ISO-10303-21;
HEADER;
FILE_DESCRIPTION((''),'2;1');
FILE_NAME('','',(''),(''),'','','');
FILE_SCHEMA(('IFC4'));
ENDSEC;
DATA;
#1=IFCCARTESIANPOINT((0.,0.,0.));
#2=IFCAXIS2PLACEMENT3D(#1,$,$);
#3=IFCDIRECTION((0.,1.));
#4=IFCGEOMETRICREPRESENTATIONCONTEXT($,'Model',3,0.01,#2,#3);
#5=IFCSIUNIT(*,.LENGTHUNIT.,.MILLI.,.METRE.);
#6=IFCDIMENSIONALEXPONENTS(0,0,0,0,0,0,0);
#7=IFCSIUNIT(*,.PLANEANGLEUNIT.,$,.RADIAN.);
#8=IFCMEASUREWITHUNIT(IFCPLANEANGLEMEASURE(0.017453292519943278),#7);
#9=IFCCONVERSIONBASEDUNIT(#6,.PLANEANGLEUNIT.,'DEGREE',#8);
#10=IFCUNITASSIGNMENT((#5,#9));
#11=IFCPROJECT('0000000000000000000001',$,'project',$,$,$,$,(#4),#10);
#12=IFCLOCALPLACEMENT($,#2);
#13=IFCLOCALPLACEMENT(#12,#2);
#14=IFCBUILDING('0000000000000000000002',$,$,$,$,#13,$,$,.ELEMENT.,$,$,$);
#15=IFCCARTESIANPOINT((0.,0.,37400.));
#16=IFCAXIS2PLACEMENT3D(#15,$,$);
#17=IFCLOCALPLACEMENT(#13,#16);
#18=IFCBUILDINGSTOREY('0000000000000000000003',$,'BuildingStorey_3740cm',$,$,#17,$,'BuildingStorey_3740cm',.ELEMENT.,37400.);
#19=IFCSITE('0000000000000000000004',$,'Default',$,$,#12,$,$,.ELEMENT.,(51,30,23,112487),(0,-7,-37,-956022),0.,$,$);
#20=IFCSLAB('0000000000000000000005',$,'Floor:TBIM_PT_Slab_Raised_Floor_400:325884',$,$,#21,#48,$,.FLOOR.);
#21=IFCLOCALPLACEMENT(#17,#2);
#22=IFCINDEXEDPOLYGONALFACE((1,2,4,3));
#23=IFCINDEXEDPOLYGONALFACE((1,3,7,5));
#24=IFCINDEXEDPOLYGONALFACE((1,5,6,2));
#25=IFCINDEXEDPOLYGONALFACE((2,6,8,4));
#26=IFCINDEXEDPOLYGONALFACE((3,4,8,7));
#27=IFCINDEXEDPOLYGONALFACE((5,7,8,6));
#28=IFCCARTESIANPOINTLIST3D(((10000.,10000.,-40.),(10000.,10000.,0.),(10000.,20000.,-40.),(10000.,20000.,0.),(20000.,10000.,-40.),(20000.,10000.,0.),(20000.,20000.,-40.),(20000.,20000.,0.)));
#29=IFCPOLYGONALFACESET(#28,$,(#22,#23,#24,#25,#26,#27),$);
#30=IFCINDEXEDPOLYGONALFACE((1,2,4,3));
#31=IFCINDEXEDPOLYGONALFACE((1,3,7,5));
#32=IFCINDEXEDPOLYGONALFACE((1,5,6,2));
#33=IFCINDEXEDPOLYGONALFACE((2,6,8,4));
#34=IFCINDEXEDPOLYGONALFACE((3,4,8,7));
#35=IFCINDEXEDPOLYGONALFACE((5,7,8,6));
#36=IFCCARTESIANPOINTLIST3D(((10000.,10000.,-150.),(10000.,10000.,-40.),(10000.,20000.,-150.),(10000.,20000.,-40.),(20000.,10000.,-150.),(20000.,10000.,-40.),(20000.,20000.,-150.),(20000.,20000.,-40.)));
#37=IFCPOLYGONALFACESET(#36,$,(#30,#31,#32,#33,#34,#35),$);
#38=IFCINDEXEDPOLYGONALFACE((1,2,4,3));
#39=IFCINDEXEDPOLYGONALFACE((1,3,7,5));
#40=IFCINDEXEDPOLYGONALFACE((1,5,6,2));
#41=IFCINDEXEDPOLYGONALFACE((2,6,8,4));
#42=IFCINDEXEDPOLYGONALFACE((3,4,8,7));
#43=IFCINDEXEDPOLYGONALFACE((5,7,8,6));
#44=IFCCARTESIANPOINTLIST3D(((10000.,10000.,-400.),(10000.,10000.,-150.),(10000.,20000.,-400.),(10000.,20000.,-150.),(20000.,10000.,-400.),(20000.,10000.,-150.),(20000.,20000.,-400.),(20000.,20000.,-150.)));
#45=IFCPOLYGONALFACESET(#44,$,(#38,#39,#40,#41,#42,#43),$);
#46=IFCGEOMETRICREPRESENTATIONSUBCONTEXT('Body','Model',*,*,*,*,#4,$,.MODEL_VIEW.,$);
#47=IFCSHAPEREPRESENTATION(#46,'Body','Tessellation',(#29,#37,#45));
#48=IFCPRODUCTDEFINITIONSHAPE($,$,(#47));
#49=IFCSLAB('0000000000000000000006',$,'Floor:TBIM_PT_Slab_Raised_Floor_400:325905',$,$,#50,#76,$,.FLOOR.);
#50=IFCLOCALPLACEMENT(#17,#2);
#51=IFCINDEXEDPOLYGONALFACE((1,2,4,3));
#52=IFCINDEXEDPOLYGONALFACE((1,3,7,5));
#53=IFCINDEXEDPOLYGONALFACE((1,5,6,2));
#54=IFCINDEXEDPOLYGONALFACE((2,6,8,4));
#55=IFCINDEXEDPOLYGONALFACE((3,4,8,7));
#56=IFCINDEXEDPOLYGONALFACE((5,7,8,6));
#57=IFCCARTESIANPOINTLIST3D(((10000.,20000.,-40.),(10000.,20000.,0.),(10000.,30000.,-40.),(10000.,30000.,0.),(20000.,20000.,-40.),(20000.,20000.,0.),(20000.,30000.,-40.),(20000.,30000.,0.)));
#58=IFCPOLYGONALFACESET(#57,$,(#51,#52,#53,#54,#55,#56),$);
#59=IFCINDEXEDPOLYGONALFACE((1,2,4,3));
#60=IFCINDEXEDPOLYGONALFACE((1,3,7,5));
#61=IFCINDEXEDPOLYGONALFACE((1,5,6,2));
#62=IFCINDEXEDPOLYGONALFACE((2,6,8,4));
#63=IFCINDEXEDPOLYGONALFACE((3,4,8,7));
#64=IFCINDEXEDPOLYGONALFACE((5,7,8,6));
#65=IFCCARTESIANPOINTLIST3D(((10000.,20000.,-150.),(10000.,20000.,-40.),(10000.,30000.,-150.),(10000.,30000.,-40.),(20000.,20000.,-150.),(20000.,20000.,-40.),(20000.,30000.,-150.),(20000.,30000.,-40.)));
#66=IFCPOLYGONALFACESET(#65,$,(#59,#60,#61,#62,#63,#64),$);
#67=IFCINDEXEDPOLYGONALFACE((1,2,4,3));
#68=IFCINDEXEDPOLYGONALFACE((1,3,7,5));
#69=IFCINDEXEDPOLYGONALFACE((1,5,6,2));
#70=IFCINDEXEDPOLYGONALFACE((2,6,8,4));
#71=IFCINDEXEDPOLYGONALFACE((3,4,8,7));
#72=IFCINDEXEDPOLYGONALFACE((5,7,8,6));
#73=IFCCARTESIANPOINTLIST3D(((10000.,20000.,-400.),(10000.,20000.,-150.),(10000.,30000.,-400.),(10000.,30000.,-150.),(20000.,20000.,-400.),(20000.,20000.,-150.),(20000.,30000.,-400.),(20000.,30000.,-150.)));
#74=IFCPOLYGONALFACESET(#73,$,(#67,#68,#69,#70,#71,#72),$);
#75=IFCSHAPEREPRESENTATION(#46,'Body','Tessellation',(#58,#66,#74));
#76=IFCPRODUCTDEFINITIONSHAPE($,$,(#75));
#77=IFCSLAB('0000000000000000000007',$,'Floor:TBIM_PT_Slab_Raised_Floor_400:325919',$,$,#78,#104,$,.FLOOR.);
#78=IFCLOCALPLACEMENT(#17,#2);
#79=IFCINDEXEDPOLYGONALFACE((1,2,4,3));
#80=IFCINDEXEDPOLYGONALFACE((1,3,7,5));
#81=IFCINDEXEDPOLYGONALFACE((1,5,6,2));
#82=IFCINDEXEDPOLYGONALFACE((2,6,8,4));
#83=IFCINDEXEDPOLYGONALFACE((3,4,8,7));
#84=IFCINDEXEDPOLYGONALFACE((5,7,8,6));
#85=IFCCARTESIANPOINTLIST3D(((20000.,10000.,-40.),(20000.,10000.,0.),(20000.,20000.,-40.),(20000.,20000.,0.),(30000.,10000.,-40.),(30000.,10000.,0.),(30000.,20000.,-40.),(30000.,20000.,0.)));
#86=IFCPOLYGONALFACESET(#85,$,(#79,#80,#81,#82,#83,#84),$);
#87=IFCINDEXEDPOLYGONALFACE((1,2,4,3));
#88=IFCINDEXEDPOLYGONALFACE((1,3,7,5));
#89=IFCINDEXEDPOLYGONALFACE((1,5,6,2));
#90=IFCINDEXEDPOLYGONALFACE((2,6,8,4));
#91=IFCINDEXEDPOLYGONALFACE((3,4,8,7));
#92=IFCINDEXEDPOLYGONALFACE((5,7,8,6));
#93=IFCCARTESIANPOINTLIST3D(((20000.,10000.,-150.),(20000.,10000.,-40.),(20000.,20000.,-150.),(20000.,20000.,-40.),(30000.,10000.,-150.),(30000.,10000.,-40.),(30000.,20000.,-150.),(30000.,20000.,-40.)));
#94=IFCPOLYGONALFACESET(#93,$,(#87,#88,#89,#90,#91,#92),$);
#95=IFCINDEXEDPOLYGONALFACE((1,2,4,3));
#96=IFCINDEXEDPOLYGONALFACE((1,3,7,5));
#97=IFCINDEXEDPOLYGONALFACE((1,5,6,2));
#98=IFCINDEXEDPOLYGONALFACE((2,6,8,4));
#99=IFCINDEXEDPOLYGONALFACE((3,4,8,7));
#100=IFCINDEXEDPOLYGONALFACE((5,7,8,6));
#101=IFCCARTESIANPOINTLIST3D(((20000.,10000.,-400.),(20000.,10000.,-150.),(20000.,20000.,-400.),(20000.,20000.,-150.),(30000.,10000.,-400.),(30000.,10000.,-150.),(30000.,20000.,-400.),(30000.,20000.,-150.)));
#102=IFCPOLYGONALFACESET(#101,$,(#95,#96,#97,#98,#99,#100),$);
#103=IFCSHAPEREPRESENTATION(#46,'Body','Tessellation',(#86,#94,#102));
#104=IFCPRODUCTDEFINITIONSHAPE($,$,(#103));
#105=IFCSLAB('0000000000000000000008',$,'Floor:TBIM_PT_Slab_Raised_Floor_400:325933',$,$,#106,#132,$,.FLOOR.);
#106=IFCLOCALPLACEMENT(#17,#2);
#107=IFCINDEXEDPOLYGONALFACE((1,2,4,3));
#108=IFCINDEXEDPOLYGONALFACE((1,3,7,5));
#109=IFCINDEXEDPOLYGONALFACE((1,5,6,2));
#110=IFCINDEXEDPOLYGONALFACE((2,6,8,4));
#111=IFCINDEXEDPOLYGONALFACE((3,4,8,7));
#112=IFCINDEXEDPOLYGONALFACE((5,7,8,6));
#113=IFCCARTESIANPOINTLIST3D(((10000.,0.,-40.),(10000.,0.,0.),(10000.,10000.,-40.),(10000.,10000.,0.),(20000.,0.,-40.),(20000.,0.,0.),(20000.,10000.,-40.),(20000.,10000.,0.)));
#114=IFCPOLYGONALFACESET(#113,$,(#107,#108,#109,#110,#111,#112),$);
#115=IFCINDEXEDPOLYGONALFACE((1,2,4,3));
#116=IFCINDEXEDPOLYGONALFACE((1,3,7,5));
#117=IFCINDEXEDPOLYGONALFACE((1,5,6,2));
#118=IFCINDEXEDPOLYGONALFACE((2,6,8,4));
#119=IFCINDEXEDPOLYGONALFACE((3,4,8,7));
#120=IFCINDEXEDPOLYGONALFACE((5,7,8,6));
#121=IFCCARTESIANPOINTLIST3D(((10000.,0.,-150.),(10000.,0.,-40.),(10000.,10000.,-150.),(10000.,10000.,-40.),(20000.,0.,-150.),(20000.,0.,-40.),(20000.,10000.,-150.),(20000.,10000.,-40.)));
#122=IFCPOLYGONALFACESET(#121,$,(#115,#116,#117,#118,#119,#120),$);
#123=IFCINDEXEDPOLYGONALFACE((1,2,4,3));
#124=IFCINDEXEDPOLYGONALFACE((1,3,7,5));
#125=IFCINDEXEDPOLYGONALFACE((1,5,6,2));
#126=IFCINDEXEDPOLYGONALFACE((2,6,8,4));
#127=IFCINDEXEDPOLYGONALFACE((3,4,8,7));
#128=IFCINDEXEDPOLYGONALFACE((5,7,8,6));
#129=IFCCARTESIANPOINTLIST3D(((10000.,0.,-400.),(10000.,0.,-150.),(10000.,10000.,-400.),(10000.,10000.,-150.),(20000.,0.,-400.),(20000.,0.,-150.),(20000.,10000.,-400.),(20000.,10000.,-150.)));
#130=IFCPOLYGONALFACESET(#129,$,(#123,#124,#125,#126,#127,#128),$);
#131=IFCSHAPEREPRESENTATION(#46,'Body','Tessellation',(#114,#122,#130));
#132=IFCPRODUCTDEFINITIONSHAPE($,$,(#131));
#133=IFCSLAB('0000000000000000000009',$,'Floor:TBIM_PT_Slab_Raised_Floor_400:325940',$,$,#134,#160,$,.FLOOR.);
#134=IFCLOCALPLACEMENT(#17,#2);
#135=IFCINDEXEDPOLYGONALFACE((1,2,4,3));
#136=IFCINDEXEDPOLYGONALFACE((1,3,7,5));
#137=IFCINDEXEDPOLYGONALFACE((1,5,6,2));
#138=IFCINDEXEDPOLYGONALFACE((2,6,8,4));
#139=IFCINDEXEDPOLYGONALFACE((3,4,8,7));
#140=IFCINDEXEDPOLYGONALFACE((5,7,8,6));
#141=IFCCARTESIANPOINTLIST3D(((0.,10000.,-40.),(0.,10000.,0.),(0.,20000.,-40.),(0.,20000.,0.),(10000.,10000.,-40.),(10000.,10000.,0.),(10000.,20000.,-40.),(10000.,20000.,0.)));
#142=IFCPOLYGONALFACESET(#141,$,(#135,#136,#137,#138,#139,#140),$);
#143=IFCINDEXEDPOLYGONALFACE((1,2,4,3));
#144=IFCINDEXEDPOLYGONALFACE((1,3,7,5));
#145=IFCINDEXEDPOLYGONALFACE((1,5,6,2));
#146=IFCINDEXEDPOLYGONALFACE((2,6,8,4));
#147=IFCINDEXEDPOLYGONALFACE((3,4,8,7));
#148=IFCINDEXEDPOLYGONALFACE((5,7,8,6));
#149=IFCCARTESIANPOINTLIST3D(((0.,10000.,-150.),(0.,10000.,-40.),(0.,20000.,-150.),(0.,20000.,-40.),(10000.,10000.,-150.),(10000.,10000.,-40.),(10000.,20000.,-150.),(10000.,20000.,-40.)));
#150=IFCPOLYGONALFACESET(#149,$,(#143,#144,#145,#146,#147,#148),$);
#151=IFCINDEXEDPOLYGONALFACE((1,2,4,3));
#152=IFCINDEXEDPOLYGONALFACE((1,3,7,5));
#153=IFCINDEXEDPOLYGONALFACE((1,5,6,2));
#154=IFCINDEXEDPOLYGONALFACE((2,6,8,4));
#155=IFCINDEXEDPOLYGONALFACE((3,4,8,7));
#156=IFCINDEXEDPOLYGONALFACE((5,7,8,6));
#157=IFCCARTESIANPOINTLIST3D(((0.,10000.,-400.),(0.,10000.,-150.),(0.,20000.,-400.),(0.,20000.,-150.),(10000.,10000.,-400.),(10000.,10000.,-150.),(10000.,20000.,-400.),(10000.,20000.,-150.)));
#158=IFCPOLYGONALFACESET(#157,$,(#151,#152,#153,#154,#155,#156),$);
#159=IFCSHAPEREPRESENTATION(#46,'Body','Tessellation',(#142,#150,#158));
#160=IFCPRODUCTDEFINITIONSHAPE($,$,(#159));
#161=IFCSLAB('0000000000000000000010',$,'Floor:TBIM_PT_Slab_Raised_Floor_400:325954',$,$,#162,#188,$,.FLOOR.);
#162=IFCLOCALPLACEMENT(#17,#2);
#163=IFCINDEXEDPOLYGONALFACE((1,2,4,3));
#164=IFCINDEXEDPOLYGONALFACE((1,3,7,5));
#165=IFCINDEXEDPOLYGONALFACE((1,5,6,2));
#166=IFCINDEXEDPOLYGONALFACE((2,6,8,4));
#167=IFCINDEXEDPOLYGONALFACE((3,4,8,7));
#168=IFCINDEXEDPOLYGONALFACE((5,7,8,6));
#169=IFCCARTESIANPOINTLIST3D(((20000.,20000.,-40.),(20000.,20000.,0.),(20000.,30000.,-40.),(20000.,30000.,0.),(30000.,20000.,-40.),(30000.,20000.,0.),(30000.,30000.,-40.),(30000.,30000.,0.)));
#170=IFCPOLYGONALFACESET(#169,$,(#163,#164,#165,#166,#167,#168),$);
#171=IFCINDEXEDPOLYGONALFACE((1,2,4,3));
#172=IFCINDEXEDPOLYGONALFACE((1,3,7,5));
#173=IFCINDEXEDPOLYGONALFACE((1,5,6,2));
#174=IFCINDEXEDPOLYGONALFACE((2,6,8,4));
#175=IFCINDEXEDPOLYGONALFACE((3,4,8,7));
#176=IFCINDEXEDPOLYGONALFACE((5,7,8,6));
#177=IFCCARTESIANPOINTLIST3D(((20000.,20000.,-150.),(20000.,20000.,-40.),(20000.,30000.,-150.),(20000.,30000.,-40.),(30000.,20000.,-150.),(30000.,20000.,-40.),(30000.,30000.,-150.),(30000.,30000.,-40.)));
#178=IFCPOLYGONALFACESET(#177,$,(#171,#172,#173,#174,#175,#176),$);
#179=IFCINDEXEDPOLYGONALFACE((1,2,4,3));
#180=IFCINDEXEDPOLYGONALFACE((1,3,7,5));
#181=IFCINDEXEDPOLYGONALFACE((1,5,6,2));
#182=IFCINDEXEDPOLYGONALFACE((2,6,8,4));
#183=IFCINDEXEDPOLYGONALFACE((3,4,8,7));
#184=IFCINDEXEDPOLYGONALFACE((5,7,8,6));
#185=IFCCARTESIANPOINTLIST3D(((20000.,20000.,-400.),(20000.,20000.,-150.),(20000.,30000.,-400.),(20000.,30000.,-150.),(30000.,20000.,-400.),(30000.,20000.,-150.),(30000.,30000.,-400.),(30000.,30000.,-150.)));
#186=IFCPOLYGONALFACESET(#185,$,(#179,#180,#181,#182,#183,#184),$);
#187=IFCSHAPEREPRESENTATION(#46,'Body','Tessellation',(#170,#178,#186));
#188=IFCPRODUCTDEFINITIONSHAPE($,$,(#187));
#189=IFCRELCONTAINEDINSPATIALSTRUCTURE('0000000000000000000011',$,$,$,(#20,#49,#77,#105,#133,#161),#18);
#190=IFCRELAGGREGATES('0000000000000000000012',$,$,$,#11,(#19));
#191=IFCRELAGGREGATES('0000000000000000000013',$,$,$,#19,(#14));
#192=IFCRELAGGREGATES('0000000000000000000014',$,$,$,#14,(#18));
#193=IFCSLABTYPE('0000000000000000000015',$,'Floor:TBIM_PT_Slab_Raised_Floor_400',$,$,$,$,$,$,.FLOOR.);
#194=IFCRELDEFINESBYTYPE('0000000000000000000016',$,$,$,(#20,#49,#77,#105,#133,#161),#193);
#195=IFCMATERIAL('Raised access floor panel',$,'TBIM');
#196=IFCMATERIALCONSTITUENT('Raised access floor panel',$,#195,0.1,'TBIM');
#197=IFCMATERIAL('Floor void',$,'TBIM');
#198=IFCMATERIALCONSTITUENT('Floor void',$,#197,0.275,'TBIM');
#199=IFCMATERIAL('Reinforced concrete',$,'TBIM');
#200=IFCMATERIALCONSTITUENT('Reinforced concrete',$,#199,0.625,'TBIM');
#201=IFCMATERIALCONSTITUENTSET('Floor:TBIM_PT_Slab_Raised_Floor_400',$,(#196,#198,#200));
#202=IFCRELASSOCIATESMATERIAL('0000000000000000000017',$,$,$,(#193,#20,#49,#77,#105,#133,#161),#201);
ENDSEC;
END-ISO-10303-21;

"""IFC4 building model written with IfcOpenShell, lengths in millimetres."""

from ifc_helpers import new_model, entity, si_unit, converted_unit, direction, frame, origin, place, context, subcontext, project, spatial, indexed_curve, outline, extrude, material, constituent, constituent_set, type_object, element, save


model = new_model("IFC4")

# Units and contexts
model_context = context("Model", 3, precision=0.01, world=origin(), true_north=direction((0.0, 1.0)))
body_context = subcontext(model_context, "Body", "Model", "MODEL_VIEW")
ifc_project = project(units=[si_unit("LENGTHUNIT", "METRE", prefix="MILLI"), converted_unit("PLANEANGLEUNIT", "DEGREE", entity("IfcPlaneAngleMeasure", 0.017453292519943278), si_unit("PLANEANGLEUNIT", "RADIAN"), dimensions=[0, 0, 0, 0, 0, 0, 0])], contexts=[model_context])

# Site, building, storey
site_placement = place(None, origin())
site = spatial("IfcSite", under=ifc_project, at=site_placement, Name="Default", CompositionType="ELEMENT", RefLatitude=(51, 30, 23, 112487), RefLongitude=(0, -7, -37, -956022), RefElevation=0.0)
building_placement = place(site_placement, origin())
building = spatial("IfcBuilding", under=site, at=building_placement, CompositionType="ELEMENT")
storey_placement = place(building_placement, frame((0.0, 0.0, 37400.0)))
storey = spatial("IfcBuildingStorey", under=building, at=storey_placement, Name="BuildingStorey_3740cm", LongName="BuildingStorey_3740cm", CompositionType="ELEMENT", Elevation=37400.0)

# Slabs
ifc_material_1 = material(Name="Raised access floor panel", Category="TBIM")
ifc_constituent_1 = constituent(ifc_material_1, Name="Raised access floor panel", Category="TBIM", fraction=0.1)
ifc_material_2 = material(Name="Floor void", Category="TBIM")
ifc_constituent_2 = constituent(ifc_material_2, Name="Floor void", Category="TBIM", fraction=0.275)
ifc_material_3 = material(Name="Reinforced concrete", Category="TBIM")
ifc_constituent_3 = constituent(ifc_material_3, Name="Reinforced concrete", Category="TBIM", fraction=0.625)
ifc_constituent_set_1 = constituent_set(constituents=[ifc_constituent_1, ifc_constituent_2, ifc_constituent_3], Name="Floor:TBIM_PT_Slab_Raised_Floor_400")
slab_type = type_object("IfcSlabType", Name="Floor:TBIM_PT_Slab_Raised_Floor_400", PredefinedType="FLOOR", material=ifc_constituent_set_1)
slab_1_placement = place(storey_placement, origin())
element("IfcSlab", 1, at=slab_1_placement, inside=storey, type_object=slab_type, material=ifc_constituent_set_1, Name="Floor:TBIM_PT_Slab_Raised_Floor_400:325884", PredefinedType="FLOOR", context=body_context, shape_type="SweptSolid", body=[
    extrude(outline(indexed_curve([(-5000.0, -5000.0), (5000.0, -5000.0), (5000.0, 5000.0), (-5000.0, 5000.0), (-5000.0, -5000.0)], self_intersect=False)), frame((15000.0, 15000.0, -40.0), z_axis=(0.0, 0.0, 1.0), x_axis=(-1.0, 0.0, 0.0)), (0.0, 0.0, 1.0), 40.0),
    extrude(outline(indexed_curve([(-5000.0, -5000.0), (5000.0, -5000.0), (5000.0, 5000.0), (-5000.0, 5000.0), (-5000.0, -5000.0)], self_intersect=False)), frame((15000.0, 15000.0, -150.0), z_axis=(0.0, 0.0, 1.0), x_axis=(-1.0, 0.0, 0.0)), (0.0, 0.0, 1.0), 110.0),
    extrude(outline(indexed_curve([(-5000.0, -5000.0), (5000.0, -5000.0), (5000.0, 5000.0), (-5000.0, 5000.0), (-5000.0, -5000.0)], self_intersect=False)), frame((15000.0, 15000.0, -400.0), z_axis=(0.0, 0.0, 1.0), x_axis=(-1.0, 0.0, 0.0)), (0.0, 0.0, 1.0), 250.0),
])
slab_2_placement = place(storey_placement, origin())
element("IfcSlab", 2, at=slab_2_placement, inside=storey, type_object=slab_type, material=ifc_constituent_set_1, Name="Floor:TBIM_PT_Slab_Raised_Floor_400:325905", PredefinedType="FLOOR", context=body_context, shape_type="SweptSolid", body=[
    extrude(outline(indexed_curve([(-5000.0, -5000.0), (5000.0, -5000.0), (5000.0, 5000.0), (-5000.0, 5000.0), (-5000.0, -5000.0)], self_intersect=False)), frame((15000.0, 25000.0, -40.0), z_axis=(0.0, 0.0, 1.0), x_axis=(-1.0, 0.0, 0.0)), (0.0, 0.0, 1.0), 40.0),
    extrude(outline(indexed_curve([(-5000.0, -5000.0), (5000.0, -5000.0), (5000.0, 5000.0), (-5000.0, 5000.0), (-5000.0, -5000.0)], self_intersect=False)), frame((15000.0, 25000.0, -150.0), z_axis=(0.0, 0.0, 1.0), x_axis=(-1.0, 0.0, 0.0)), (0.0, 0.0, 1.0), 110.0),
    extrude(outline(indexed_curve([(-5000.0, -5000.0), (5000.0, -5000.0), (5000.0, 5000.0), (-5000.0, 5000.0), (-5000.0, -5000.0)], self_intersect=False)), frame((15000.0, 25000.0, -400.0), z_axis=(0.0, 0.0, 1.0), x_axis=(-1.0, 0.0, 0.0)), (0.0, 0.0, 1.0), 250.0),
])
slab_3_placement = place(storey_placement, origin())
element("IfcSlab", 3, at=slab_3_placement, inside=storey, type_object=slab_type, material=ifc_constituent_set_1, Name="Floor:TBIM_PT_Slab_Raised_Floor_400:325919", PredefinedType="FLOOR", context=body_context, shape_type="SweptSolid", body=[
    extrude(outline(indexed_curve([(-5000.0, -5000.0), (5000.0, -5000.0), (5000.0, 5000.0), (-5000.0, 5000.0), (-5000.0, -5000.0)], self_intersect=False)), frame((25000.0, 15000.0, -40.0), z_axis=(0.0, 0.0, 1.0), x_axis=(-1.0, 0.0, 0.0)), (0.0, 0.0, 1.0), 40.0),
    extrude(outline(indexed_curve([(-5000.0, -5000.0), (5000.0, -5000.0), (5000.0, 5000.0), (-5000.0, 5000.0), (-5000.0, -5000.0)], self_intersect=False)), frame((25000.0, 15000.0, -150.0), z_axis=(0.0, 0.0, 1.0), x_axis=(-1.0, 0.0, 0.0)), (0.0, 0.0, 1.0), 110.0),
    extrude(outline(indexed_curve([(-5000.0, -5000.0), (5000.0, -5000.0), (5000.0, 5000.0), (-5000.0, 5000.0), (-5000.0, -5000.0)], self_intersect=False)), frame((25000.0, 15000.0, -400.0), z_axis=(0.0, 0.0, 1.0), x_axis=(-1.0, 0.0, 0.0)), (0.0, 0.0, 1.0), 250.0),
])
slab_4_placement = place(storey_placement, origin())
element("IfcSlab", 4, at=slab_4_placement, inside=storey, type_object=slab_type, material=ifc_constituent_set_1, Name="Floor:TBIM_PT_Slab_Raised_Floor_400:325933", PredefinedType="FLOOR", context=body_context, shape_type="SweptSolid", body=[
    extrude(outline(indexed_curve([(-5000.0, -5000.0), (5000.0, -5000.0), (5000.0, 5000.0), (-5000.0, 5000.0), (-5000.0, -5000.0)], self_intersect=False)), frame((15000.0, 5000.0, -40.0), z_axis=(0.0, 0.0, 1.0), x_axis=(0.0, 1.0, 0.0)), (0.0, 0.0, 1.0), 40.0),
    extrude(outline(indexed_curve([(-5000.0, -5000.0), (5000.0, -5000.0), (5000.0, 5000.0), (-5000.0, 5000.0), (-5000.0, -5000.0)], self_intersect=False)), frame((15000.0, 5000.0, -150.0), z_axis=(0.0, 0.0, 1.0), x_axis=(0.0, 1.0, 0.0)), (0.0, 0.0, 1.0), 110.0),
    extrude(outline(indexed_curve([(-5000.0, -5000.0), (5000.0, -5000.0), (5000.0, 5000.0), (-5000.0, 5000.0), (-5000.0, -5000.0)], self_intersect=False)), frame((15000.0, 5000.0, -400.0), z_axis=(0.0, 0.0, 1.0), x_axis=(0.0, 1.0, 0.0)), (0.0, 0.0, 1.0), 250.0),
])
slab_5_placement = place(storey_placement, origin())
element("IfcSlab", 5, at=slab_5_placement, inside=storey, type_object=slab_type, material=ifc_constituent_set_1, Name="Floor:TBIM_PT_Slab_Raised_Floor_400:325940", PredefinedType="FLOOR", context=body_context, shape_type="SweptSolid", body=[
    extrude(outline(indexed_curve([(-5000.0, -5000.0), (5000.0, -5000.0), (5000.0, 5000.0), (-5000.0, 5000.0), (-5000.0, -5000.0)], self_intersect=False)), frame((5000.0, 15000.0, -40.0), z_axis=(0.0, 0.0, 1.0), x_axis=(0.0, 1.0, 0.0)), (0.0, 0.0, 1.0), 40.0),
    extrude(outline(indexed_curve([(-5000.0, -5000.0), (5000.0, -5000.0), (5000.0, 5000.0), (-5000.0, 5000.0), (-5000.0, -5000.0)], self_intersect=False)), frame((5000.0, 15000.0, -150.0), z_axis=(0.0, 0.0, 1.0), x_axis=(0.0, 1.0, 0.0)), (0.0, 0.0, 1.0), 110.0),
    extrude(outline(indexed_curve([(-5000.0, -5000.0), (5000.0, -5000.0), (5000.0, 5000.0), (-5000.0, 5000.0), (-5000.0, -5000.0)], self_intersect=False)), frame((5000.0, 15000.0, -400.0), z_axis=(0.0, 0.0, 1.0), x_axis=(0.0, 1.0, 0.0)), (0.0, 0.0, 1.0), 250.0),
])
slab_6_placement = place(storey_placement, origin())
element("IfcSlab", 6, at=slab_6_placement, inside=storey, type_object=slab_type, material=ifc_constituent_set_1, Name="Floor:TBIM_PT_Slab_Raised_Floor_400:325954", PredefinedType="FLOOR", context=body_context, shape_type="SweptSolid", body=[
    extrude(outline(indexed_curve([(-5000.0, -5000.0), (5000.0, -5000.0), (5000.0, 5000.0), (-5000.0, 5000.0), (-5000.0, -5000.0)], self_intersect=False)), frame((25000.0, 25000.0, -40.0), z_axis=(0.0, 0.0, 1.0), x_axis=(-1.0, 0.0, 0.0)), (0.0, 0.0, 1.0), 40.0),
    extrude(outline(indexed_curve([(-5000.0, -5000.0), (5000.0, -5000.0), (5000.0, 5000.0), (-5000.0, 5000.0), (-5000.0, -5000.0)], self_intersect=False)), frame((25000.0, 25000.0, -150.0), z_axis=(0.0, 0.0, 1.0), x_axis=(-1.0, 0.0, 0.0)), (0.0, 0.0, 1.0), 110.0),
    extrude(outline(indexed_curve([(-5000.0, -5000.0), (5000.0, -5000.0), (5000.0, 5000.0), (-5000.0, 5000.0), (-5000.0, -5000.0)], self_intersect=False)), frame((25000.0, 25000.0, -400.0), z_axis=(0.0, 0.0, 1.0), x_axis=(-1.0, 0.0, 0.0)), (0.0, 0.0, 1.0), 250.0),
])

save(model, "model.ifc")
